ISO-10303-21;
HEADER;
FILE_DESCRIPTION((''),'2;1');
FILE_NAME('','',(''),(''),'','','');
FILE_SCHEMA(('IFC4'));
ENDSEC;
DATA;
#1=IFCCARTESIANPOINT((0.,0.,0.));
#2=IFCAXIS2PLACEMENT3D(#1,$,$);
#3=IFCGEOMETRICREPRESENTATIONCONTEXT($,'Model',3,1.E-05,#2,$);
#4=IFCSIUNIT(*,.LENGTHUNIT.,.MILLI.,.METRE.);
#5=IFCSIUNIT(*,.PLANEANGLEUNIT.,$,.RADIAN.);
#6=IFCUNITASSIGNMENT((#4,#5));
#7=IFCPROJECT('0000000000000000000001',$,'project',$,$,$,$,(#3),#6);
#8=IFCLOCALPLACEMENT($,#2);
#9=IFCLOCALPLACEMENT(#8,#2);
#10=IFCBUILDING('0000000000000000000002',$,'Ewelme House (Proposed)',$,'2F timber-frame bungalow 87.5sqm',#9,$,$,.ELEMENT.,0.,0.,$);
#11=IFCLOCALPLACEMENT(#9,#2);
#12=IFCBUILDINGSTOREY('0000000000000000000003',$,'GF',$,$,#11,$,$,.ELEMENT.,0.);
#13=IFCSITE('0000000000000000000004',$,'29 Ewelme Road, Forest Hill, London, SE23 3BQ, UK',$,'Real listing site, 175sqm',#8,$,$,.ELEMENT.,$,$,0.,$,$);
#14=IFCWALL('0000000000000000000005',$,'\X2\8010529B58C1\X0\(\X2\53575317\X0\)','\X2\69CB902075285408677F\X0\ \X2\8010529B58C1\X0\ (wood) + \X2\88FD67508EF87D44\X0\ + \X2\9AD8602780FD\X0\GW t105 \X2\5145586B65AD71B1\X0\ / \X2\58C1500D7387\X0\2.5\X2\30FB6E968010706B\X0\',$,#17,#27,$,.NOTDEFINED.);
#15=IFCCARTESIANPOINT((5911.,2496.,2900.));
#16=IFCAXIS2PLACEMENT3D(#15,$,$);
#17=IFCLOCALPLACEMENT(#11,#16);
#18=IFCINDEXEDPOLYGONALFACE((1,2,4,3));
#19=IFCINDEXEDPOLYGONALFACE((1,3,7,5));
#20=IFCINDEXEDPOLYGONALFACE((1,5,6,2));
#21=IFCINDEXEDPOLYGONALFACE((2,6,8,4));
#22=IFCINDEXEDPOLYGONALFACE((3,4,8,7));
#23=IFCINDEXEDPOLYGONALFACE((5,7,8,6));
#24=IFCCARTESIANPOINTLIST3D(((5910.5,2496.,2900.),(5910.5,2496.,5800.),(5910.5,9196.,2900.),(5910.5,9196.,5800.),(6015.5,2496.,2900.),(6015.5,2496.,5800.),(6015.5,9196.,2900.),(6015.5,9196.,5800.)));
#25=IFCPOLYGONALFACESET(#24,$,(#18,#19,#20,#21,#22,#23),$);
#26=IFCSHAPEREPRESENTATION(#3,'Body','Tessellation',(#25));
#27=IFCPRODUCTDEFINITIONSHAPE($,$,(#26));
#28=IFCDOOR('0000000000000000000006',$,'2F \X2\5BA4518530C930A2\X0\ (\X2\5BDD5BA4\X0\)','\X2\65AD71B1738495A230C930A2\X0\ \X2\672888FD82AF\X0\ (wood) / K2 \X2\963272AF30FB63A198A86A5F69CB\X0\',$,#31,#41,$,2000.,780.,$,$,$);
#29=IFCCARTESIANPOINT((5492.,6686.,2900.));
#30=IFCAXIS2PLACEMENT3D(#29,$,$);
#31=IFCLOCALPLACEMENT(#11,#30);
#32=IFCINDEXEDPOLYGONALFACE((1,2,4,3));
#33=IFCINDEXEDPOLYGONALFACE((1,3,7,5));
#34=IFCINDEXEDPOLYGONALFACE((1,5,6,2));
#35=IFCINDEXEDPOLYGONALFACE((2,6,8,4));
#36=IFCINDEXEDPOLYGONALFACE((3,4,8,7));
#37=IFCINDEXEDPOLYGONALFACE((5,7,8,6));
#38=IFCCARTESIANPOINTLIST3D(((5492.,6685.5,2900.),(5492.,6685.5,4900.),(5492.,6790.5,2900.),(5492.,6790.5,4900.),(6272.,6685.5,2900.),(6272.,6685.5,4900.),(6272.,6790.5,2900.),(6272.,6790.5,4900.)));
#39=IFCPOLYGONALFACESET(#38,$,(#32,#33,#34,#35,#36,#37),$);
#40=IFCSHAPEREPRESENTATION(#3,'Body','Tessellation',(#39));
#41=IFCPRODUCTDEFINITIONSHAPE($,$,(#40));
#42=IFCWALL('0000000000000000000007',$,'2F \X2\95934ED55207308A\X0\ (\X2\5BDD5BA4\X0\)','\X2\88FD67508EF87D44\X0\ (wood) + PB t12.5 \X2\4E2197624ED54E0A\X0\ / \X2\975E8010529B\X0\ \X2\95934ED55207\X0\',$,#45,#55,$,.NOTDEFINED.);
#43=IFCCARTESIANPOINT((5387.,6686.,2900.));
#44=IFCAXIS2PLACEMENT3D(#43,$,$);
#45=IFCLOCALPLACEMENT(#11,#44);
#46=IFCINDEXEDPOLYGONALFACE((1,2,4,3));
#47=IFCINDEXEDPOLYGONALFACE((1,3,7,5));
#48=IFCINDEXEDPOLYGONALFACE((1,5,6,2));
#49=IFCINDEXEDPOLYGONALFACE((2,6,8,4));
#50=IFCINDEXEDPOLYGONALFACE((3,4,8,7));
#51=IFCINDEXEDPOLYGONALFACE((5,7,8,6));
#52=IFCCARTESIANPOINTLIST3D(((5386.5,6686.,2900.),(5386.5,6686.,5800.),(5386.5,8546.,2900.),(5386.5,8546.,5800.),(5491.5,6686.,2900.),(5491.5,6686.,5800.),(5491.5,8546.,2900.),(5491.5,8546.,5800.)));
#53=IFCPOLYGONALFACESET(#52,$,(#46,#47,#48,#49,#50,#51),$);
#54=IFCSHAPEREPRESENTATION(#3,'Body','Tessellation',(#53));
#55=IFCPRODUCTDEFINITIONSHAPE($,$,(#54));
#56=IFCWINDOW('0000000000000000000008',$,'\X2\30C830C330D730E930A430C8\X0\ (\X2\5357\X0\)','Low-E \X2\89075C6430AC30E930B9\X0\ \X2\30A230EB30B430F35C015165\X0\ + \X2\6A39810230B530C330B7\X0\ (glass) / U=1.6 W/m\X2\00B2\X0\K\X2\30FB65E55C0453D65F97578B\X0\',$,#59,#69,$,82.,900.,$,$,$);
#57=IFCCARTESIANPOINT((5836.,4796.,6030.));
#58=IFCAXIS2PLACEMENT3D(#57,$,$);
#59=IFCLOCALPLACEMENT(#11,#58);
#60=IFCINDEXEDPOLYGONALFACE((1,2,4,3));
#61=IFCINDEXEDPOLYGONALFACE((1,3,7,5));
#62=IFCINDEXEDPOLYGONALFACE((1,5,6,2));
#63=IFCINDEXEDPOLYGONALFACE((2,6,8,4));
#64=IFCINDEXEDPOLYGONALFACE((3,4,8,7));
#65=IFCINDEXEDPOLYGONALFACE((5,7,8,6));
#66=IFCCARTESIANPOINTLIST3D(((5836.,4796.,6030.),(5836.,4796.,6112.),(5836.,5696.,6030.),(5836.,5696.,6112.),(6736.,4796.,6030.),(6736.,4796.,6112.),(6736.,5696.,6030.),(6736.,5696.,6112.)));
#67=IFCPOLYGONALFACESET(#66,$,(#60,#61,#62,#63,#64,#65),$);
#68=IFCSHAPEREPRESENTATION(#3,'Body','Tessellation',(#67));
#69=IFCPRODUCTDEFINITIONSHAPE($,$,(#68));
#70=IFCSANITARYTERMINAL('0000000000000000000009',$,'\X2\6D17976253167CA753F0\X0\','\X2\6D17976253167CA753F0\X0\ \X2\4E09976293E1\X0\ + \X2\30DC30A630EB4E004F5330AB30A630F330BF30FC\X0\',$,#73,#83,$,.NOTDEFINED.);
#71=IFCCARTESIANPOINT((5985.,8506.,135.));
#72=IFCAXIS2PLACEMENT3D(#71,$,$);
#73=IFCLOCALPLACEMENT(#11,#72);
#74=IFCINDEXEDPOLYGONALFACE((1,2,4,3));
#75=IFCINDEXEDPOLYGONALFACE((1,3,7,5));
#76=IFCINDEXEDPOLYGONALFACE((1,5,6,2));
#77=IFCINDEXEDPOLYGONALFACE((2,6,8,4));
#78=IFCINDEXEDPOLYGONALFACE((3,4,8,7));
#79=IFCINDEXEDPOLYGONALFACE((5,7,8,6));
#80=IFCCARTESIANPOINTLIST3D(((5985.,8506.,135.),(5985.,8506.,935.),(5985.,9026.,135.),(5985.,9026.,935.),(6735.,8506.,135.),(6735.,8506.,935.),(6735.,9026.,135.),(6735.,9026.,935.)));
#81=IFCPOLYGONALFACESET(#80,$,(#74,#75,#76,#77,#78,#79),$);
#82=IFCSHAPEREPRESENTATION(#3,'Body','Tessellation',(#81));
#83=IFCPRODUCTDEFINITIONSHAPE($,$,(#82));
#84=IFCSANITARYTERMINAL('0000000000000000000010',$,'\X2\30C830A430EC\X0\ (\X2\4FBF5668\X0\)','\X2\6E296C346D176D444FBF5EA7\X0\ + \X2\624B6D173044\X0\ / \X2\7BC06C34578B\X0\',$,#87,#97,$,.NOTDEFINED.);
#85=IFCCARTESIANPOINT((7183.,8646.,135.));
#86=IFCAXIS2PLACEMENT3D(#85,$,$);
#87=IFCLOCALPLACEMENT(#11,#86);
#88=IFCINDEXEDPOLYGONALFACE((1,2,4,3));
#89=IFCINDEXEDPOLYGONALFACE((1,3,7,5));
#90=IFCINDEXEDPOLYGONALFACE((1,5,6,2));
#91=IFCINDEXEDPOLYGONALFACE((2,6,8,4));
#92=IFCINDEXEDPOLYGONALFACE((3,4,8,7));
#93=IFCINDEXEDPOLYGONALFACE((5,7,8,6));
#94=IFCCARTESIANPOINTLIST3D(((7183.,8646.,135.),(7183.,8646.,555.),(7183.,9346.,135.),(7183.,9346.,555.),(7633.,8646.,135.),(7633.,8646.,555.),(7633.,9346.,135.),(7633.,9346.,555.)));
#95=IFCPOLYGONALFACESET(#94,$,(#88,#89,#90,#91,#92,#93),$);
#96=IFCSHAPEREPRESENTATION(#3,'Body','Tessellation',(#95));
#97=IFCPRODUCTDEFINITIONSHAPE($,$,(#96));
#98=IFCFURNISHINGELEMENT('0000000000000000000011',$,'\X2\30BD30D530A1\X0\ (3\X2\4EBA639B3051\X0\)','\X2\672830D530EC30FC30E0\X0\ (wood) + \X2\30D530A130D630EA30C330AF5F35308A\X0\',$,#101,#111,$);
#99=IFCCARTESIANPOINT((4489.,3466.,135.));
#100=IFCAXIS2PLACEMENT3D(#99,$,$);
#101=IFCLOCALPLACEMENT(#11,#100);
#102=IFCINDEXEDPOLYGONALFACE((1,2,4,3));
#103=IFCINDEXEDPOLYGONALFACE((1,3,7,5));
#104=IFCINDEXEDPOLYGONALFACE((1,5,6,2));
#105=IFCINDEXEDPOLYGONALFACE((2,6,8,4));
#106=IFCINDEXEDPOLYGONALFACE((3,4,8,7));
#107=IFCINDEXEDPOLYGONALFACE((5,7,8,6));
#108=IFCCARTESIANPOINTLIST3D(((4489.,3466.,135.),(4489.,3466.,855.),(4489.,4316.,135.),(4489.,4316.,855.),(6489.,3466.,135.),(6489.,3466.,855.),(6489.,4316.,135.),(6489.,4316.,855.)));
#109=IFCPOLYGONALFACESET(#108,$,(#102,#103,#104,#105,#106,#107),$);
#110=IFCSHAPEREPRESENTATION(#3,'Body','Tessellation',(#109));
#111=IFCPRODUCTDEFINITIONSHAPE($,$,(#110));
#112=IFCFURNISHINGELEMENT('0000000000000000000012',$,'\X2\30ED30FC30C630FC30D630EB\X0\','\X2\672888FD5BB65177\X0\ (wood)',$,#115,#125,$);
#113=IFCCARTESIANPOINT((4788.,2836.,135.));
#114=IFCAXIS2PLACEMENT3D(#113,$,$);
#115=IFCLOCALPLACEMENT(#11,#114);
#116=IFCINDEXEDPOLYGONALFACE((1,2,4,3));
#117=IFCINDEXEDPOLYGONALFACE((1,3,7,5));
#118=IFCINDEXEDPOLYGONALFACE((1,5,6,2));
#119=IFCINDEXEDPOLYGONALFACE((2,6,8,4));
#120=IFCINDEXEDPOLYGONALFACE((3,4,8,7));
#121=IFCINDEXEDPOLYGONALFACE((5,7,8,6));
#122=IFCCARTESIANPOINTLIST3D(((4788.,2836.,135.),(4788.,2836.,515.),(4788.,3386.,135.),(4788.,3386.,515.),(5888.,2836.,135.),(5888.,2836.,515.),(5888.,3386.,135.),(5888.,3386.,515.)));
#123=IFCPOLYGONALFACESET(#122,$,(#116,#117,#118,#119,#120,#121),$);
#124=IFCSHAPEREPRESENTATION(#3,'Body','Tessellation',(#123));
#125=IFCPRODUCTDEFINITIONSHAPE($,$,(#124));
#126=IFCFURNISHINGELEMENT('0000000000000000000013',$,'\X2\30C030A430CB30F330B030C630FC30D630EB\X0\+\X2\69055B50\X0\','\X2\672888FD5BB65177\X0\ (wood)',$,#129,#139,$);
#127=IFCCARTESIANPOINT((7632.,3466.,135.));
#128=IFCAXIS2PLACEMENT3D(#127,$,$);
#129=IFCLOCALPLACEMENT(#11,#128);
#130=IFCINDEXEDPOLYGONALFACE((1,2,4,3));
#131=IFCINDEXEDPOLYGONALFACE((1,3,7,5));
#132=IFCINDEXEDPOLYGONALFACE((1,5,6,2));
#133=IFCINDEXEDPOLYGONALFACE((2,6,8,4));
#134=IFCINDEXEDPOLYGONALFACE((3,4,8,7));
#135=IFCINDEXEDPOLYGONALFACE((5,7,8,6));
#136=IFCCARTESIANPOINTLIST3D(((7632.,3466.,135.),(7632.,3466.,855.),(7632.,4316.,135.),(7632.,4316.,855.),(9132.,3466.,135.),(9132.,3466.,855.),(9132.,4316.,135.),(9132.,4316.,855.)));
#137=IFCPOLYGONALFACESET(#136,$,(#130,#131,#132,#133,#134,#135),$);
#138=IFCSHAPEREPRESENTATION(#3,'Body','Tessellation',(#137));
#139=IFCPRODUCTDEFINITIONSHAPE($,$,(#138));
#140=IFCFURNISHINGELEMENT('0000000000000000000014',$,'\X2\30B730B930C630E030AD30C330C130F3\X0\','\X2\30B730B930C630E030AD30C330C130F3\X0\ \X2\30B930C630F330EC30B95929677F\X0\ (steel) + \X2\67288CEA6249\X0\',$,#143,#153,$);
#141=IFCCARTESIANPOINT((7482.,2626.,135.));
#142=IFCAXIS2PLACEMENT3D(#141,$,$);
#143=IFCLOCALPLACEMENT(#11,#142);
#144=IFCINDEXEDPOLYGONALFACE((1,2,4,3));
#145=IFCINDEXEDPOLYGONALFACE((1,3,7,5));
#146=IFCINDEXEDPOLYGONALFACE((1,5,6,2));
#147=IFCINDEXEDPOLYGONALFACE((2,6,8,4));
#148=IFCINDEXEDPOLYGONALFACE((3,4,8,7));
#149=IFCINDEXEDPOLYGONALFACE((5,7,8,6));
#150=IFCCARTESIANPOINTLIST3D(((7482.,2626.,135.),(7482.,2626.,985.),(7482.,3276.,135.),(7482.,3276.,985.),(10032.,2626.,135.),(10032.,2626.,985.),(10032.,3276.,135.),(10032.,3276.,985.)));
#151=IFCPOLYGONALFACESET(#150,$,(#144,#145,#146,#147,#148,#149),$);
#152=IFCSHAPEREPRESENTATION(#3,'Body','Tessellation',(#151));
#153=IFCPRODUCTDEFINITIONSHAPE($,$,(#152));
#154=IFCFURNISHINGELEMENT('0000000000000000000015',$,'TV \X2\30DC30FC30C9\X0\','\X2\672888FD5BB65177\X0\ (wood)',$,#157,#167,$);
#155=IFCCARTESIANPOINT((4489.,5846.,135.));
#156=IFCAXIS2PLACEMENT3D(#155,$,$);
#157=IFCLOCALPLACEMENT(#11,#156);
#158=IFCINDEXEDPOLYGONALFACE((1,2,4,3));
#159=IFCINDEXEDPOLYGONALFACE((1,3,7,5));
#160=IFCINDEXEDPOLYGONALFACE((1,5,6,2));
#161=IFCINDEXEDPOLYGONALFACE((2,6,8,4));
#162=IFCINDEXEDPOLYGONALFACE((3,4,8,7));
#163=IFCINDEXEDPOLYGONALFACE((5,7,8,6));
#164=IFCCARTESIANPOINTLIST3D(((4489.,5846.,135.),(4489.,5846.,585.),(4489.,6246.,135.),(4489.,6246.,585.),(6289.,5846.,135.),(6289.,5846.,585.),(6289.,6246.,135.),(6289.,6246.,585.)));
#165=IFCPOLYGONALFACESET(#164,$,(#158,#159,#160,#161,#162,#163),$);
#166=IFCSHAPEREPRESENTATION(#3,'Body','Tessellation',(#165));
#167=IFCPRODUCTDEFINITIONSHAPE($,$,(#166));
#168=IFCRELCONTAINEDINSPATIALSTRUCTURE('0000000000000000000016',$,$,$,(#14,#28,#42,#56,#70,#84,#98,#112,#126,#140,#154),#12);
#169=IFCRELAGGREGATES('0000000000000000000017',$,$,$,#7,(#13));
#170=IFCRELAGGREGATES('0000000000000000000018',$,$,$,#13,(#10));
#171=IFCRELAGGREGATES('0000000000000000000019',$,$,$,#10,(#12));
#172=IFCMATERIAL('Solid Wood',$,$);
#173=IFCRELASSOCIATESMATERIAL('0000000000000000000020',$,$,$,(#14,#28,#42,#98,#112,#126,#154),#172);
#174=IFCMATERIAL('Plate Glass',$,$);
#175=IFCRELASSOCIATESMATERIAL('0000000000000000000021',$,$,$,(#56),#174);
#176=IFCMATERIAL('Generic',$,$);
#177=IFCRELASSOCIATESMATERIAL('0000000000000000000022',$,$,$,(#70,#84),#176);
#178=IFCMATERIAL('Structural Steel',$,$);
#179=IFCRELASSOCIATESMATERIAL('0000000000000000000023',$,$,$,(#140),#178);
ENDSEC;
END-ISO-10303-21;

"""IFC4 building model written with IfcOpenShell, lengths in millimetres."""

from ifc_helpers import new_model, si_unit, frame, frame_2d, origin, place, context, project, spatial, rectangle, extrude, material, element, fill, save


model = new_model("IFC4")

# Units and contexts
model_context = context("Model", 3, precision=1e-05, world=origin())
ifc_project = project(units=[si_unit("LENGTHUNIT", "METRE", prefix="MILLI"), si_unit("PLANEANGLEUNIT", "RADIAN")], contexts=[model_context])

# Site, building, storey
site_placement = place(None, origin())
site = spatial("IfcSite", under=ifc_project, at=site_placement, Name="29 Ewelme Road, Forest Hill, London, SE23 3BQ, UK", ObjectType="Real listing site, 175sqm", CompositionType="ELEMENT", RefElevation=0.0)
building_placement = place(site_placement, origin())
building = spatial("IfcBuilding", under=site, at=building_placement, Name="Ewelme House (Proposed)", ObjectType="2F timber-frame bungalow 87.5sqm", CompositionType="ELEMENT", ElevationOfRefHeight=0.0, ElevationOfTerrain=0.0)
storey_placement = place(building_placement, origin())
storey = spatial("IfcBuildingStorey", under=building, at=storey_placement, Name="GF", CompositionType="ELEMENT", Elevation=0.0)

# Shared definitions
ifc_material_1 = material(Name="Solid Wood")

# Wall, opening, door
wall_1_placement = place(storey_placement, frame((5911.0, 2496.0, 2900.0)))
wall_1 = element("IfcWall", 1, at=wall_1_placement, inside=storey, material=ifc_material_1, Name="耐力壁(南北)", Description="構造用合板 耐力壁 (wood) + 製材軸組 + 高性能GW t105 充填断熱 / 壁倍率2.5・準耐火", PredefinedType="NOTDEFINED", context=model_context, shape_type="SweptSolid", body=[
    extrude(rectangle(XDim=105.0, YDim=6700.0, at=frame_2d((52.0, 3350.0))), frame((5911.0, 2496.0, 2900.0)), (0.0, 0.0, 1.0), 2900.0),
])
opening_1_placement = place(storey_placement, frame((5492.0, 6686.0, 2900.0)))
opening_1 = element("IfcOpeningElement", 2, at=opening_1_placement, cuts=wall_1, PredefinedType="NOTDEFINED", context=model_context, shape_type="SweptSolid", body=[
    extrude(rectangle(XDim=780.0, YDim=105.0, at=frame_2d((390.0, 52.0))), frame((5492.0, 6686.0, 2900.0)), (0.0, 0.0, 1.0), 2000.0),
])
door_1_placement = place(storey_placement, frame((5492.0, 6686.0, 2900.0)))
door_1 = element("IfcDoor", 3, at=door_1_placement, inside=storey, material=ifc_material_1, Name="2F 室内ドア (寝室)", Description="断熱玄関ドア 木製芯 (wood) / K2 防犯・採風機構", OverallHeight=2000.0, OverallWidth=780.0, context=model_context, shape_type="SweptSolid", body=[
    extrude(rectangle(XDim=780.0, YDim=105.0, at=frame_2d((390.0, 52.0))), frame((5492.0, 6686.0, 2900.0)), (0.0, 0.0, 1.0), 2000.0),
])
fill(opening_1, door_1)

# Wall
wall_2_placement = place(storey_placement, frame((5387.0, 6686.0, 2900.0)))
element("IfcWall", 4, at=wall_2_placement, inside=storey, material=ifc_material_1, Name="2F 間仕切り (寝室)", Description="製材軸組 (wood) + PB t12.5 両面仕上 / 非耐力 間仕切", PredefinedType="NOTDEFINED", context=model_context, shape_type="SweptSolid", body=[
    extrude(rectangle(XDim=105.0, YDim=1860.0, at=frame_2d((52.0, 930.0))), frame((5387.0, 6686.0, 2900.0)), (0.0, 0.0, 1.0), 2900.0),
])

# Window
ifc_material_2 = material(Name="Plate Glass")
window_placement = place(storey_placement, frame((5836.0, 4796.0, 6030.0)))
element("IfcWindow", 5, at=window_placement, inside=storey, material=ifc_material_2, Name="トップライト (南)", Description="Low-E 複層ガラス アルゴン封入 + 樹脂サッシ (glass) / U=1.6 W/m²K・日射取得型", OverallHeight=82.0, OverallWidth=900.0, context=model_context, shape_type="SweptSolid", body=[
    extrude(rectangle(XDim=900.0, YDim=900.0, at=frame_2d((450.0, 450.0))), frame((5836.0, 4796.0, 6030.0)), (0.0, 0.0, 1.0), 82.0),
])

# Sanitary terminals
ifc_material_3 = material(Name="Generic")
sanitary_terminal_1_placement = place(storey_placement, frame((5985.0, 8506.0, 135.0)))
element("IfcSanitaryTerminal", 6, at=sanitary_terminal_1_placement, inside=storey, material=ifc_material_3, Name="洗面化粧台", Description="洗面化粧台 三面鏡 + ボウル一体カウンター", PredefinedType="NOTDEFINED", context=model_context, shape_type="SweptSolid", body=[
    extrude(rectangle(XDim=750.0, YDim=520.0, at=frame_2d((375.0, 260.0))), frame((5985.0, 8506.0, 135.0)), (0.0, 0.0, 1.0), 800.0),
])
sanitary_terminal_2_placement = place(storey_placement, frame((7183.0, 8646.0, 135.0)))
element("IfcSanitaryTerminal", 7, at=sanitary_terminal_2_placement, inside=storey, material=ifc_material_3, Name="トイレ (便器)", Description="温水洗浄便座 + 手洗い / 節水型", PredefinedType="NOTDEFINED", context=model_context, shape_type="SweptSolid", body=[
    extrude(rectangle(XDim=450.0, YDim=700.0, at=frame_2d((225.0, 350.0))), frame((7183.0, 8646.0, 135.0)), (0.0, 0.0, 1.0), 420.0),
])

# Furnishing elements
furnishing_1_placement = place(storey_placement, frame((4489.0, 3466.0, 135.0)))
element("IfcFurnishingElement", 8, at=furnishing_1_placement, inside=storey, material=ifc_material_1, Name="ソファ (3人掛け)", Description="木フレーム (wood) + ファブリック張り", context=model_context, shape_type="SweptSolid", body=[
    extrude(rectangle(XDim=2000.0, YDim=850.0, at=frame_2d((1000.0, 425.0))), frame((4489.0, 3466.0, 135.0)), (0.0, 0.0, 1.0), 720.0),
])
furnishing_2_placement = place(storey_placement, frame((4788.0, 2836.0, 135.0)))
element("IfcFurnishingElement", 9, at=furnishing_2_placement, inside=storey, material=ifc_material_1, Name="ローテーブル", Description="木製家具 (wood)", context=model_context, shape_type="SweptSolid", body=[
    extrude(rectangle(XDim=1100.0, YDim=550.0, at=frame_2d((550.0, 275.0))), frame((4788.0, 2836.0, 135.0)), (0.0, 0.0, 1.0), 380.0),
])
furnishing_3_placement = place(storey_placement, frame((7632.0, 3466.0, 135.0)))
element("IfcFurnishingElement", 10, at=furnishing_3_placement, inside=storey, material=ifc_material_1, Name="ダイニングテーブル+椅子", Description="木製家具 (wood)", context=model_context, shape_type="SweptSolid", body=[
    extrude(rectangle(XDim=1500.0, YDim=850.0, at=frame_2d((750.0, 425.0))), frame((7632.0, 3466.0, 135.0)), (0.0, 0.0, 1.0), 720.0),
])
ifc_material_4 = material(Name="Structural Steel")
furnishing_4_placement = place(storey_placement, frame((7482.0, 2626.0, 135.0)))
element("IfcFurnishingElement", 11, at=furnishing_4_placement, inside=storey, material=ifc_material_4, Name="システムキッチン", Description="システムキッチン ステンレス天板 (steel) + 木質扉", context=model_context, shape_type="SweptSolid", body=[
    extrude(rectangle(XDim=2550.0, YDim=650.0, at=frame_2d((1275.0, 325.0))), frame((7482.0, 2626.0, 135.0)), (0.0, 0.0, 1.0), 850.0),
])
furnishing_5_placement = place(storey_placement, frame((4489.0, 5846.0, 135.0)))
element("IfcFurnishingElement", 12, at=furnishing_5_placement, inside=storey, material=ifc_material_1, Name="TV ボード", Description="木製家具 (wood)", context=model_context, shape_type="SweptSolid", body=[
    extrude(rectangle(XDim=1800.0, YDim=400.0, at=frame_2d((900.0, 200.0))), frame((4489.0, 5846.0, 135.0)), (0.0, 0.0, 1.0), 450.0),
])

save(model, "model.ifc")
